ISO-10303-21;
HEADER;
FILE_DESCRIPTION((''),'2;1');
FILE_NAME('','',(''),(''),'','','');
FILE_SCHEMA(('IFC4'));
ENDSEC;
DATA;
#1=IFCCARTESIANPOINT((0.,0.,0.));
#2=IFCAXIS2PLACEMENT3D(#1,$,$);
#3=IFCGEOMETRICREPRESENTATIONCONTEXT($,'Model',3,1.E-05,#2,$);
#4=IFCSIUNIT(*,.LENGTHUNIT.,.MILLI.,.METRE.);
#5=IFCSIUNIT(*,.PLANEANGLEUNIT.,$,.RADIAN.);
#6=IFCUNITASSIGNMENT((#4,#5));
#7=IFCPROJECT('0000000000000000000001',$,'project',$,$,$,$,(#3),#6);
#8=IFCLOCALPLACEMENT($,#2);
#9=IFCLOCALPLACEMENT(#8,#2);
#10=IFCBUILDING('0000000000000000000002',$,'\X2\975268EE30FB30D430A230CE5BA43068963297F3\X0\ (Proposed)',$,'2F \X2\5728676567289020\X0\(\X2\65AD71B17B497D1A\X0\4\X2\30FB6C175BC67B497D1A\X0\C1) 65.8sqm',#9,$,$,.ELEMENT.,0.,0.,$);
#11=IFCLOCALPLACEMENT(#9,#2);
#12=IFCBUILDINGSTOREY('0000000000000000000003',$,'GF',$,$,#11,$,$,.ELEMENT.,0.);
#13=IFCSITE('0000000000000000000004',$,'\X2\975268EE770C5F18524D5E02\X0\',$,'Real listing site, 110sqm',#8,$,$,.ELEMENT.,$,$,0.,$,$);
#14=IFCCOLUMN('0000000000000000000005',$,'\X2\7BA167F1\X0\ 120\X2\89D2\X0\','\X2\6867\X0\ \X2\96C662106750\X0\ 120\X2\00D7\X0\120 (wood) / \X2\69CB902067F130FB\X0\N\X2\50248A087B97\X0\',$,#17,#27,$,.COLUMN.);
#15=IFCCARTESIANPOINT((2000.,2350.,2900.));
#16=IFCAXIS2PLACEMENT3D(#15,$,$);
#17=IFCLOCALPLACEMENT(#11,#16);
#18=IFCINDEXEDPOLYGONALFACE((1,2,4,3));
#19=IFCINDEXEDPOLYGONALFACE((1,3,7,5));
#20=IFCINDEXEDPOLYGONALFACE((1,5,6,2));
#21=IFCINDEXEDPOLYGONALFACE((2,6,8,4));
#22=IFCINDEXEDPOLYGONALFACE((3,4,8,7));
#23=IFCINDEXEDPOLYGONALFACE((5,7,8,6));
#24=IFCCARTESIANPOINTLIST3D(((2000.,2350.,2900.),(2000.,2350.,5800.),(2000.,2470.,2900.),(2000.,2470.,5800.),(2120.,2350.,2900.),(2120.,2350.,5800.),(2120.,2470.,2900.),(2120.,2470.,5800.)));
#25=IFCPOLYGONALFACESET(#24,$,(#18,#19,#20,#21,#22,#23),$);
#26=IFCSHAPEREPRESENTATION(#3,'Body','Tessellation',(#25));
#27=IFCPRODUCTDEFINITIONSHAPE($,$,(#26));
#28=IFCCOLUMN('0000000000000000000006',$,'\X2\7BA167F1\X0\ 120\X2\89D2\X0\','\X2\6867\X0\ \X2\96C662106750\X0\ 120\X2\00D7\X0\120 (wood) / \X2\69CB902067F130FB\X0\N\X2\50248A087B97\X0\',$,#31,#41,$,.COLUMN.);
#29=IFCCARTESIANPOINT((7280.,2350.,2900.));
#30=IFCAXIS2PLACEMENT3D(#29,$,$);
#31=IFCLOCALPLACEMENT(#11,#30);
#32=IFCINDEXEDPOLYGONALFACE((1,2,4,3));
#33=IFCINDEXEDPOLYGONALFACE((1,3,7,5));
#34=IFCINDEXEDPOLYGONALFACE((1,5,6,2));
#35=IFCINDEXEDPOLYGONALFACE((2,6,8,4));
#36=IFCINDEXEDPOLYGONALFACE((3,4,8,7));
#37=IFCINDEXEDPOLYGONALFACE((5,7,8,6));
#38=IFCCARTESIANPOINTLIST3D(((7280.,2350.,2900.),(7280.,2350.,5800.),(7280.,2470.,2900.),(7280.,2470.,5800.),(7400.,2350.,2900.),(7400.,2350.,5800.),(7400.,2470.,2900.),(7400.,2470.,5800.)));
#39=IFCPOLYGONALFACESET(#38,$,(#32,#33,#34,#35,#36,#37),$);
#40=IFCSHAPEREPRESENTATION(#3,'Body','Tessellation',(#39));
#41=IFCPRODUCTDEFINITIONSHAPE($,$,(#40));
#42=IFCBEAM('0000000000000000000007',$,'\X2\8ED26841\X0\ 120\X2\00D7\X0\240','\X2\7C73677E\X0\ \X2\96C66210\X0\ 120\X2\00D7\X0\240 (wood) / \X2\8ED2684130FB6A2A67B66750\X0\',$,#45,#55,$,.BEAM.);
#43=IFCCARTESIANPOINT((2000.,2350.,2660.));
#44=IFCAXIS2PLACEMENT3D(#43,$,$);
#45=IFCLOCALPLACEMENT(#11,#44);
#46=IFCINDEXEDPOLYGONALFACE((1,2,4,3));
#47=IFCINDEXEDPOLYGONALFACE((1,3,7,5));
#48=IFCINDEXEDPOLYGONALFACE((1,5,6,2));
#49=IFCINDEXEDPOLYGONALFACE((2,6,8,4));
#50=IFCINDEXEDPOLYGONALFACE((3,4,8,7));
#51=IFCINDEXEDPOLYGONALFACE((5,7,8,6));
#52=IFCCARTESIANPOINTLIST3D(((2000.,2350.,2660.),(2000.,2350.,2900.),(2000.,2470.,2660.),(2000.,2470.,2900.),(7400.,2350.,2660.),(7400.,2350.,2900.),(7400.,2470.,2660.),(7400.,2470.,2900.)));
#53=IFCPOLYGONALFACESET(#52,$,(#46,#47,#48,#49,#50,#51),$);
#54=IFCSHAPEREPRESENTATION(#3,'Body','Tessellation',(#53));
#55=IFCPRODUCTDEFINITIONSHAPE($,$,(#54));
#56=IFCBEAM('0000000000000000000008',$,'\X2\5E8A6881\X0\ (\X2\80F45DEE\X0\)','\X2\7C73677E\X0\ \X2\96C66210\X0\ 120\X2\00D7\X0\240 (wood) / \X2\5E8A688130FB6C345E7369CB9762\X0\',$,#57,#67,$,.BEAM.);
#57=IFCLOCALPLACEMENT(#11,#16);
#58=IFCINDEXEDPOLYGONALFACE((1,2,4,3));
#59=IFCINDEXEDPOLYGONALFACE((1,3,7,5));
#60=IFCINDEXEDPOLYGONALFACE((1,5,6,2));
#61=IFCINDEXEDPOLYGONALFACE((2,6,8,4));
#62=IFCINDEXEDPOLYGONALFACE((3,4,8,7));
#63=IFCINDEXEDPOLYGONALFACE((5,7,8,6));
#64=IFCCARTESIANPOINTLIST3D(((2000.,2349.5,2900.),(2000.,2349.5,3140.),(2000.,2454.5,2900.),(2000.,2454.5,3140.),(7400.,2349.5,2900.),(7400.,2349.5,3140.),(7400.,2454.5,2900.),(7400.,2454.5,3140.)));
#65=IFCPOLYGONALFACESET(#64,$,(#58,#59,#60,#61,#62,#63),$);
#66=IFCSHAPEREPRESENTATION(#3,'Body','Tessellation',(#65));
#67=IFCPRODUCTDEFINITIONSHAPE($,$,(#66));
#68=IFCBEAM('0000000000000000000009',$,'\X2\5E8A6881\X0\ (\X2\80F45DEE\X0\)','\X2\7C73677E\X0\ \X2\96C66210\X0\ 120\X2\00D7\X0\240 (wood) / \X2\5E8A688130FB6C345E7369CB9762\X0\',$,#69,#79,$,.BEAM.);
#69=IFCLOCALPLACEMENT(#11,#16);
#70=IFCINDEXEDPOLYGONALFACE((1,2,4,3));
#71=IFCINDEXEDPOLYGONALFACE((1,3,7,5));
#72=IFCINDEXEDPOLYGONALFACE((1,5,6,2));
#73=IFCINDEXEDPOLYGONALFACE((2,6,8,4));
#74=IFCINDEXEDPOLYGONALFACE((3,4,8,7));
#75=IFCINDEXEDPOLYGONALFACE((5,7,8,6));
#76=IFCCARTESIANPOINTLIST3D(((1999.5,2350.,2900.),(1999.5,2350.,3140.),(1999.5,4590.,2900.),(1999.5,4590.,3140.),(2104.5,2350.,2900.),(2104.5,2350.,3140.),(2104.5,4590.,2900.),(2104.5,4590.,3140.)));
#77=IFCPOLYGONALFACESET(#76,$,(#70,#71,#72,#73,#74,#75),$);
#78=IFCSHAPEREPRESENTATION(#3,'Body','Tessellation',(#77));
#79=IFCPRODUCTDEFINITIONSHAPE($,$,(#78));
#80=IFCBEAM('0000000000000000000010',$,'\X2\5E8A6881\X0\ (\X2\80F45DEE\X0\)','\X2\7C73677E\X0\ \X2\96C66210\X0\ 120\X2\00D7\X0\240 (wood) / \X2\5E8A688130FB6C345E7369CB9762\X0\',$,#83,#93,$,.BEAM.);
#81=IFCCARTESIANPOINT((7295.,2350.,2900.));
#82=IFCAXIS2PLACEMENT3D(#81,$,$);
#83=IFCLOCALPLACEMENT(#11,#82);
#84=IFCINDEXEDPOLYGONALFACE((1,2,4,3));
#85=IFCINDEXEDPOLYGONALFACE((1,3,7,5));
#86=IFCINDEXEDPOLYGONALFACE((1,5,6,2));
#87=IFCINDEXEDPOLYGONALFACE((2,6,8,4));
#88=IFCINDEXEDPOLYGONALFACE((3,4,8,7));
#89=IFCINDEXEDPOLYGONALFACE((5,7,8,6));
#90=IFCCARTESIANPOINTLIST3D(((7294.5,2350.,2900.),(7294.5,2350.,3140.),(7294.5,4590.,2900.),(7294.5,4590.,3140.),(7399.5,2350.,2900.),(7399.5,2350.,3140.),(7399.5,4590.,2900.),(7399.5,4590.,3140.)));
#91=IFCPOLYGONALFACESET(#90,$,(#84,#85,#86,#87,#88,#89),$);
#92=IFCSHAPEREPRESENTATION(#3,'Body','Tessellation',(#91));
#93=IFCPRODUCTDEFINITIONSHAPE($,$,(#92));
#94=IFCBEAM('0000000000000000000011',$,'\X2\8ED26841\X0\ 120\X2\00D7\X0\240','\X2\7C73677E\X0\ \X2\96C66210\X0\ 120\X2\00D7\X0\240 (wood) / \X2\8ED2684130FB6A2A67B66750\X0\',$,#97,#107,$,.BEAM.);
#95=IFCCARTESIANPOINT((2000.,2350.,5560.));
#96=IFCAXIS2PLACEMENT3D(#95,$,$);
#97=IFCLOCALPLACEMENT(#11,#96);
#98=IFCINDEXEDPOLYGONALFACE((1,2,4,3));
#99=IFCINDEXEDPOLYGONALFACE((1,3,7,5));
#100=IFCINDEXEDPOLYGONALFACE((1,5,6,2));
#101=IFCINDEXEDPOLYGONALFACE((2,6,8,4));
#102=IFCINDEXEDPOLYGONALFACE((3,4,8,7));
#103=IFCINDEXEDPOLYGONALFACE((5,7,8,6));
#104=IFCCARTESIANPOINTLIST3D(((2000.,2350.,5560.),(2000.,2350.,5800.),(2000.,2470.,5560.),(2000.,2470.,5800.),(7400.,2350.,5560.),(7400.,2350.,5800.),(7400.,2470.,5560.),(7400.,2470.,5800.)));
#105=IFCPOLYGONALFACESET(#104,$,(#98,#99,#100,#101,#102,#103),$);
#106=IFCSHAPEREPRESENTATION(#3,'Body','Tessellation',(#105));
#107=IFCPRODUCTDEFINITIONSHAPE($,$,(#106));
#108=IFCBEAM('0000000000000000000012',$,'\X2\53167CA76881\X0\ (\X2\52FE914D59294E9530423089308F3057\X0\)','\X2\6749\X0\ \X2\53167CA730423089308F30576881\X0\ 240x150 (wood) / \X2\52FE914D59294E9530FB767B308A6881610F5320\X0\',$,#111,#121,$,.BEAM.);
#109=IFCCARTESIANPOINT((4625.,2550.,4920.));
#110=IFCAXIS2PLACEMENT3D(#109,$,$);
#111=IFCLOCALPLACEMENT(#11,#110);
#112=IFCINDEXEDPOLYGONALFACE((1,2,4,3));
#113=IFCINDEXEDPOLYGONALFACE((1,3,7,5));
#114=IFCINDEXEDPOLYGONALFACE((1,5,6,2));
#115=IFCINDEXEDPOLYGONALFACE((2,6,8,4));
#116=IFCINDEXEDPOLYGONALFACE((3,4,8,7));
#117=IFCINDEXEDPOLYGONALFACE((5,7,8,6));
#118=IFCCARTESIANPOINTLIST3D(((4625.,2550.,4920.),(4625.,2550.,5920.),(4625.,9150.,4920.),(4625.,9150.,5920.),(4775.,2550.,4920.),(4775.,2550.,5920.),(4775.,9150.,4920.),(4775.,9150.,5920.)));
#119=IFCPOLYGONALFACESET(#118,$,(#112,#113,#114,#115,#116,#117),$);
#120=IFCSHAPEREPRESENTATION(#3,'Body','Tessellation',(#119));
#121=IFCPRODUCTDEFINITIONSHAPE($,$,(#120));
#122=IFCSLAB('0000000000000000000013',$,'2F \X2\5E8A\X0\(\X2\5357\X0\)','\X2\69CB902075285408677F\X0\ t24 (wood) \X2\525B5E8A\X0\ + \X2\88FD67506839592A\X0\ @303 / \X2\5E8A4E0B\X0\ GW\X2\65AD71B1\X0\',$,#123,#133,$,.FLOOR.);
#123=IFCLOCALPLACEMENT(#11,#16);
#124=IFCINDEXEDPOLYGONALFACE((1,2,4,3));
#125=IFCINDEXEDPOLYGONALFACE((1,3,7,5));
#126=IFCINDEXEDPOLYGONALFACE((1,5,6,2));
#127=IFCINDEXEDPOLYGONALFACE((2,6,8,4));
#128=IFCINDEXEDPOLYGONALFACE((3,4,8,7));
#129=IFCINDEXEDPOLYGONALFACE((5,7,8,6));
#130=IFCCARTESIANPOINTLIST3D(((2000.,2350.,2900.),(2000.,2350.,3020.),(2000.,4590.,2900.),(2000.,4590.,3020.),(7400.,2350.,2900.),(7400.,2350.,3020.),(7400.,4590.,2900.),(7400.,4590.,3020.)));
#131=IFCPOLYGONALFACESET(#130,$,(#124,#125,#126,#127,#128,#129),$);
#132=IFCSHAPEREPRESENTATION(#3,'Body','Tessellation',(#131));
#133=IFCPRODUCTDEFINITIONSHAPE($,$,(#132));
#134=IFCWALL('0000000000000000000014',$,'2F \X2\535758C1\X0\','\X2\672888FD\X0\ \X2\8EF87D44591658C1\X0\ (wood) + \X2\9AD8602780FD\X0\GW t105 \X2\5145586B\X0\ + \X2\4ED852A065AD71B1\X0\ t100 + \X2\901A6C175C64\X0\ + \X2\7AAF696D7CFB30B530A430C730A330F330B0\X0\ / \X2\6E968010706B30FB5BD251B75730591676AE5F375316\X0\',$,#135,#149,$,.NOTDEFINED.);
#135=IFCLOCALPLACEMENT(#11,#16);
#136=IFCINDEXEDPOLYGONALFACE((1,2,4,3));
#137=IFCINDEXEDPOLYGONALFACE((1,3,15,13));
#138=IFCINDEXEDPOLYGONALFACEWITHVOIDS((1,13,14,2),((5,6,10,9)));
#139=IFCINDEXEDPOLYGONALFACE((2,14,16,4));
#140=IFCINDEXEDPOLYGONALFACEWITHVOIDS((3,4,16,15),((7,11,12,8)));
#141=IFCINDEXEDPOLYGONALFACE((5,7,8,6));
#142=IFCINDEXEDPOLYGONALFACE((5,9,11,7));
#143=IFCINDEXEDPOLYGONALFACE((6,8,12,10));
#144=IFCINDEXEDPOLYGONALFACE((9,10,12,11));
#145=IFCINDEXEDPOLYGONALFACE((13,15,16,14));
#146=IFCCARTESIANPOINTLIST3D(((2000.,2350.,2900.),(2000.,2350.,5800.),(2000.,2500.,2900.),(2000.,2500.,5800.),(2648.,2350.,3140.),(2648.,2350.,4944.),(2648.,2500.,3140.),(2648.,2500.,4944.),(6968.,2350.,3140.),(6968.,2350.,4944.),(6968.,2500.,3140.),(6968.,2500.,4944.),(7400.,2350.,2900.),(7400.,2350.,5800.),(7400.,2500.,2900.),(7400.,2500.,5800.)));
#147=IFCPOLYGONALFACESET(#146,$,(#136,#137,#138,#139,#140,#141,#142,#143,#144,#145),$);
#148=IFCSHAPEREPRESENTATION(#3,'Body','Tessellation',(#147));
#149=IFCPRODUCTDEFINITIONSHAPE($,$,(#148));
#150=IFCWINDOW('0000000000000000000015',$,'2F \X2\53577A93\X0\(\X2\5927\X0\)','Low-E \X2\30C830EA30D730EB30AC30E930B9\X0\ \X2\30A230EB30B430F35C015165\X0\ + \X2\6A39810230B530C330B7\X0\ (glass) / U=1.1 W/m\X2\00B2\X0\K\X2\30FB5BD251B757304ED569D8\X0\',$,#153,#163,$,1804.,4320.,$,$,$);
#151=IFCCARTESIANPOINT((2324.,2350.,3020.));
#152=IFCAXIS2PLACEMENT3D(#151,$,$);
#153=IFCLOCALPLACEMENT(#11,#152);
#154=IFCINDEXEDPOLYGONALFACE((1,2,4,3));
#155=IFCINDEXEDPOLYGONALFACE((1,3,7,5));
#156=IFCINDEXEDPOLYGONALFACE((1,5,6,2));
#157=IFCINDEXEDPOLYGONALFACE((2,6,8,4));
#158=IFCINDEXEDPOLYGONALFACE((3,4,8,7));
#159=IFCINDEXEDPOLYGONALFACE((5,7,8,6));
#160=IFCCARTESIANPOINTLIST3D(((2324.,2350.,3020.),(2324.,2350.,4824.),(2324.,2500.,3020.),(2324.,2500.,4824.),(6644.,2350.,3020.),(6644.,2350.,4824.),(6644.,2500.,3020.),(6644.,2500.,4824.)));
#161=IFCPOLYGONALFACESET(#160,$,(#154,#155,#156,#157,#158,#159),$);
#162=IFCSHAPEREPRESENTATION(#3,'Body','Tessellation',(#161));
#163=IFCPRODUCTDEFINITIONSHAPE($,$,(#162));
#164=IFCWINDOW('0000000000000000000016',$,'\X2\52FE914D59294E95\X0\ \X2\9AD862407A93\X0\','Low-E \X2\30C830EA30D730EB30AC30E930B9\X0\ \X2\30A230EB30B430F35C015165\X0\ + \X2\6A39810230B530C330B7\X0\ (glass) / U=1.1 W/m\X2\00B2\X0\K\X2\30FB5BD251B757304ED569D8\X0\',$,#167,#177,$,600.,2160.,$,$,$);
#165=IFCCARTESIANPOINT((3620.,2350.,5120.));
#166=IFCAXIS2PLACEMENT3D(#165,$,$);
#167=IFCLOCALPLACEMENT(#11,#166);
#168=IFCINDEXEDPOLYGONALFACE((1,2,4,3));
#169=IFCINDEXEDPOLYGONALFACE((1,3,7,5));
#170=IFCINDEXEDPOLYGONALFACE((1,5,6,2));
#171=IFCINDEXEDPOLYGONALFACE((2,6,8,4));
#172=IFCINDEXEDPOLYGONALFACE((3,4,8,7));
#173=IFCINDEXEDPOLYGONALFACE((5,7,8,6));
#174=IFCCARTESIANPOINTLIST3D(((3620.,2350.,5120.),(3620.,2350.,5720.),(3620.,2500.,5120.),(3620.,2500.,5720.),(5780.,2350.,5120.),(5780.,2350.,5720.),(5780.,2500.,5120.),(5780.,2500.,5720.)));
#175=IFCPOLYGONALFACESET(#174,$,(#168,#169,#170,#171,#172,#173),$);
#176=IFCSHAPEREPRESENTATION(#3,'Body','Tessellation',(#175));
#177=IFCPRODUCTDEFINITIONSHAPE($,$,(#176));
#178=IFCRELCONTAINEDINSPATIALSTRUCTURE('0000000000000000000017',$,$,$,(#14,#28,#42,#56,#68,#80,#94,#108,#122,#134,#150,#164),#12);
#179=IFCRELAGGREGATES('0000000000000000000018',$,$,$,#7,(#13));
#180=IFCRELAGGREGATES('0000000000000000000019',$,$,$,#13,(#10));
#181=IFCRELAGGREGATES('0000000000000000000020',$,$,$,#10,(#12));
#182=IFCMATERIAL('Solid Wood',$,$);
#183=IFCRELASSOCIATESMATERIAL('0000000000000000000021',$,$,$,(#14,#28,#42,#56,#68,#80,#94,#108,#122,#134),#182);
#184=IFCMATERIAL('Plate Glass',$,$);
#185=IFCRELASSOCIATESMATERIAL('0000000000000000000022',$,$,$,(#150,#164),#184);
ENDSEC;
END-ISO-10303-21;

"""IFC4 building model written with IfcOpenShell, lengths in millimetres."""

from ifc_helpers import new_model, si_unit, frame, frame_2d, origin, place, context, project, spatial, rectangle, extrude, material, element, fill, save


model = new_model("IFC4")

# Units and contexts
model_context = context("Model", 3, precision=1e-05, world=origin())
ifc_project = project(units=[si_unit("LENGTHUNIT", "METRE", prefix="MILLI"), si_unit("PLANEANGLEUNIT", "RADIAN")], contexts=[model_context])

# Site, building, storey
site_placement = place(None, origin())
site = spatial("IfcSite", under=ifc_project, at=site_placement, Name="青森県弘前市", ObjectType="Real listing site, 110sqm", CompositionType="ELEMENT", RefElevation=0.0)
building_placement = place(site_placement, origin())
building = spatial("IfcBuilding", under=site, at=building_placement, Name="青森・ピアノ室と防音 (Proposed)", ObjectType="2F 在来木造(断熱等級4・気密等級C1) 65.8sqm", CompositionType="ELEMENT", ElevationOfRefHeight=0.0, ElevationOfTerrain=0.0)
storey_placement = place(building_placement, origin())
storey = spatial("IfcBuildingStorey", under=building, at=storey_placement, Name="GF", CompositionType="ELEMENT", Elevation=0.0)

# Columns
ifc_material_1 = material(Name="Solid Wood")
column_1_placement = place(storey_placement, frame((2000.0, 2350.0, 2900.0)))
element("IfcColumn", 1, at=column_1_placement, inside=storey, material=ifc_material_1, Name="管柱 120角", Description="桧 集成材 120×120 (wood) / 構造柱・N値計算", PredefinedType="COLUMN", context=model_context, shape_type="SweptSolid", body=[
    extrude(rectangle(XDim=120.0, YDim=120.0, at=frame_2d((60.0, 60.0))), frame((2000.0, 2350.0, 2900.0)), (0.0, 0.0, 1.0), 2900.0),
])
column_2_placement = place(storey_placement, frame((7280.0, 2350.0, 2900.0)))
element("IfcColumn", 2, at=column_2_placement, inside=storey, material=ifc_material_1, Name="管柱 120角", Description="桧 集成材 120×120 (wood) / 構造柱・N値計算", PredefinedType="COLUMN", context=model_context, shape_type="SweptSolid", body=[
    extrude(rectangle(XDim=120.0, YDim=120.0, at=frame_2d((60.0, 60.0))), frame((7280.0, 2350.0, 2900.0)), (0.0, 0.0, 1.0), 2900.0),
])

# Beams
beam_1_placement = place(storey_placement, frame((2000.0, 2350.0, 2660.0)))
element("IfcBeam", 3, at=beam_1_placement, inside=storey, material=ifc_material_1, Name="軒桁 120×240", Description="米松 集成 120×240 (wood) / 軒桁・横架材", PredefinedType="BEAM", context=model_context, shape_type="SweptSolid", body=[
    extrude(rectangle(XDim=5400.0, YDim=120.0, at=frame_2d((2700.0, 60.0))), frame((2000.0, 2350.0, 2660.0)), (0.0, 0.0, 1.0), 240.0),
])
beam_2_placement = place(storey_placement, frame((2000.0, 2350.0, 2900.0)))
element("IfcBeam", 4, at=beam_2_placement, inside=storey, material=ifc_material_1, Name="床梁 (胴差)", Description="米松 集成 120×240 (wood) / 床梁・水平構面", PredefinedType="BEAM", context=model_context, shape_type="SweptSolid", body=[
    extrude(rectangle(XDim=5400.0, YDim=105.0, at=frame_2d((2700.0, 52.0))), frame((2000.0, 2350.0, 2900.0)), (0.0, 0.0, 1.0), 240.0),
])
beam_3_placement = place(storey_placement, frame((2000.0, 2350.0, 2900.0)))
element("IfcBeam", 5, at=beam_3_placement, inside=storey, material=ifc_material_1, Name="床梁 (胴差)", Description="米松 集成 120×240 (wood) / 床梁・水平構面", PredefinedType="BEAM", context=model_context, shape_type="SweptSolid", body=[
    extrude(rectangle(XDim=105.0, YDim=2240.0, at=frame_2d((52.0, 1120.0))), frame((2000.0, 2350.0, 2900.0)), (0.0, 0.0, 1.0), 240.0),
])
beam_4_placement = place(storey_placement, frame((7295.0, 2350.0, 2900.0)))
element("IfcBeam", 6, at=beam_4_placement, inside=storey, material=ifc_material_1, Name="床梁 (胴差)", Description="米松 集成 120×240 (wood) / 床梁・水平構面", PredefinedType="BEAM", context=model_context, shape_type="SweptSolid", body=[
    extrude(rectangle(XDim=105.0, YDim=2240.0, at=frame_2d((52.0, 1120.0))), frame((7295.0, 2350.0, 2900.0)), (0.0, 0.0, 1.0), 240.0),
])
beam_5_placement = place(storey_placement, frame((2000.0, 2350.0, 5560.0)))
element("IfcBeam", 7, at=beam_5_placement, inside=storey, material=ifc_material_1, Name="軒桁 120×240", Description="米松 集成 120×240 (wood) / 軒桁・横架材", PredefinedType="BEAM", context=model_context, shape_type="SweptSolid", body=[
    extrude(rectangle(XDim=5400.0, YDim=120.0, at=frame_2d((2700.0, 60.0))), frame((2000.0, 2350.0, 5560.0)), (0.0, 0.0, 1.0), 240.0),
])
beam_6_placement = place(storey_placement, frame((4625.0, 2550.0, 4920.0)))
element("IfcBeam", 8, at=beam_6_placement, inside=storey, material=ifc_material_1, Name="化粧梁 (勾配天井あらわし)", Description="杉 化粧あらわし梁 240x150 (wood) / 勾配天井・登り梁意匠", PredefinedType="BEAM", context=model_context, shape_type="SweptSolid", body=[
    extrude(rectangle(XDim=150.0, YDim=6600.0, at=frame_2d((75.0, 3300.0))), frame((4625.0, 2550.0, 4920.0)), (0.0, 0.0, 1.0), 1000.0),
])

# Slab
slab_placement = place(storey_placement, frame((2000.0, 2350.0, 2900.0)))
element("IfcSlab", 9, at=slab_placement, inside=storey, material=ifc_material_1, Name="2F 床(南)", Description="構造用合板 t24 (wood) 剛床 + 製材根太 @303 / 床下 GW断熱", PredefinedType="FLOOR", context=model_context, shape_type="SweptSolid", body=[
    extrude(rectangle(XDim=5400.0, YDim=2240.0, at=frame_2d((2700.0, 1120.0))), frame((2000.0, 2350.0, 2900.0)), (0.0, 0.0, 1.0), 120.0),
])

# Wall, openings, windows
wall_1_placement = place(storey_placement, frame((2000.0, 2350.0, 2900.0)))
wall_1 = element("IfcWall", 10, at=wall_1_placement, inside=storey, material=ifc_material_1, Name="2F 南壁", Description="木製 軸組外壁 (wood) + 高性能GW t105 充填 + 付加断熱 t100 + 通気層 + 窯業系サイディング / 準耐火・寒冷地外皮強化", PredefinedType="NOTDEFINED", context=model_context, shape_type="SweptSolid", body=[
    extrude(rectangle(XDim=5400.0, YDim=150.0, at=frame_2d((2700.0, 75.0))), frame((2000.0, 2350.0, 2900.0)), (0.0, 0.0, 1.0), 2900.0),
])
opening_1_placement = place(storey_placement, frame((2324.0, 2350.0, 3020.0)))
opening_1 = element("IfcOpeningElement", 11, at=opening_1_placement, cuts=wall_1, PredefinedType="NOTDEFINED", context=model_context, shape_type="SweptSolid", body=[
    extrude(rectangle(XDim=4320.0, YDim=150.0, at=frame_2d((2160.0, 75.0))), frame((2324.0, 2350.0, 3020.0)), (0.0, 0.0, 1.0), 1804.0),
])
opening_2_placement = place(storey_placement, frame((3620.0, 2350.0, 5120.0)))
opening_2 = element("IfcOpeningElement", 12, at=opening_2_placement, cuts=wall_1, PredefinedType="NOTDEFINED", context=model_context, shape_type="SweptSolid", body=[
    extrude(rectangle(XDim=2160.0, YDim=150.0, at=frame_2d((1080.0, 75.0))), frame((3620.0, 2350.0, 5120.0)), (0.0, 0.0, 1.0), 600.0),
])
ifc_material_2 = material(Name="Plate Glass")
window_1_placement = place(storey_placement, frame((2324.0, 2350.0, 3020.0)))
window_1 = element("IfcWindow", 13, at=window_1_placement, inside=storey, material=ifc_material_2, Name="2F 南窓(大)", Description="Low-E トリプルガラス アルゴン封入 + 樹脂サッシ (glass) / U=1.1 W/m²K・寒冷地仕様", OverallHeight=1804.0, OverallWidth=4320.0, context=model_context, shape_type="SweptSolid", body=[
    extrude(rectangle(XDim=4320.0, YDim=150.0, at=frame_2d((2160.0, 75.0))), frame((2324.0, 2350.0, 3020.0)), (0.0, 0.0, 1.0), 1804.0),
])
fill(opening_1, window_1)
window_2_placement = place(storey_placement, frame((3620.0, 2350.0, 5120.0)))
window_2 = element("IfcWindow", 14, at=window_2_placement, inside=storey, material=ifc_material_2, Name="勾配天井 高所窓", Description="Low-E トリプルガラス アルゴン封入 + 樹脂サッシ (glass) / U=1.1 W/m²K・寒冷地仕様", OverallHeight=600.0, OverallWidth=2160.0, context=model_context, shape_type="SweptSolid", body=[
    extrude(rectangle(XDim=2160.0, YDim=150.0, at=frame_2d((1080.0, 75.0))), frame((3620.0, 2350.0, 5120.0)), (0.0, 0.0, 1.0), 600.0),
])
fill(opening_2, window_2)

save(model, "model.ifc")
